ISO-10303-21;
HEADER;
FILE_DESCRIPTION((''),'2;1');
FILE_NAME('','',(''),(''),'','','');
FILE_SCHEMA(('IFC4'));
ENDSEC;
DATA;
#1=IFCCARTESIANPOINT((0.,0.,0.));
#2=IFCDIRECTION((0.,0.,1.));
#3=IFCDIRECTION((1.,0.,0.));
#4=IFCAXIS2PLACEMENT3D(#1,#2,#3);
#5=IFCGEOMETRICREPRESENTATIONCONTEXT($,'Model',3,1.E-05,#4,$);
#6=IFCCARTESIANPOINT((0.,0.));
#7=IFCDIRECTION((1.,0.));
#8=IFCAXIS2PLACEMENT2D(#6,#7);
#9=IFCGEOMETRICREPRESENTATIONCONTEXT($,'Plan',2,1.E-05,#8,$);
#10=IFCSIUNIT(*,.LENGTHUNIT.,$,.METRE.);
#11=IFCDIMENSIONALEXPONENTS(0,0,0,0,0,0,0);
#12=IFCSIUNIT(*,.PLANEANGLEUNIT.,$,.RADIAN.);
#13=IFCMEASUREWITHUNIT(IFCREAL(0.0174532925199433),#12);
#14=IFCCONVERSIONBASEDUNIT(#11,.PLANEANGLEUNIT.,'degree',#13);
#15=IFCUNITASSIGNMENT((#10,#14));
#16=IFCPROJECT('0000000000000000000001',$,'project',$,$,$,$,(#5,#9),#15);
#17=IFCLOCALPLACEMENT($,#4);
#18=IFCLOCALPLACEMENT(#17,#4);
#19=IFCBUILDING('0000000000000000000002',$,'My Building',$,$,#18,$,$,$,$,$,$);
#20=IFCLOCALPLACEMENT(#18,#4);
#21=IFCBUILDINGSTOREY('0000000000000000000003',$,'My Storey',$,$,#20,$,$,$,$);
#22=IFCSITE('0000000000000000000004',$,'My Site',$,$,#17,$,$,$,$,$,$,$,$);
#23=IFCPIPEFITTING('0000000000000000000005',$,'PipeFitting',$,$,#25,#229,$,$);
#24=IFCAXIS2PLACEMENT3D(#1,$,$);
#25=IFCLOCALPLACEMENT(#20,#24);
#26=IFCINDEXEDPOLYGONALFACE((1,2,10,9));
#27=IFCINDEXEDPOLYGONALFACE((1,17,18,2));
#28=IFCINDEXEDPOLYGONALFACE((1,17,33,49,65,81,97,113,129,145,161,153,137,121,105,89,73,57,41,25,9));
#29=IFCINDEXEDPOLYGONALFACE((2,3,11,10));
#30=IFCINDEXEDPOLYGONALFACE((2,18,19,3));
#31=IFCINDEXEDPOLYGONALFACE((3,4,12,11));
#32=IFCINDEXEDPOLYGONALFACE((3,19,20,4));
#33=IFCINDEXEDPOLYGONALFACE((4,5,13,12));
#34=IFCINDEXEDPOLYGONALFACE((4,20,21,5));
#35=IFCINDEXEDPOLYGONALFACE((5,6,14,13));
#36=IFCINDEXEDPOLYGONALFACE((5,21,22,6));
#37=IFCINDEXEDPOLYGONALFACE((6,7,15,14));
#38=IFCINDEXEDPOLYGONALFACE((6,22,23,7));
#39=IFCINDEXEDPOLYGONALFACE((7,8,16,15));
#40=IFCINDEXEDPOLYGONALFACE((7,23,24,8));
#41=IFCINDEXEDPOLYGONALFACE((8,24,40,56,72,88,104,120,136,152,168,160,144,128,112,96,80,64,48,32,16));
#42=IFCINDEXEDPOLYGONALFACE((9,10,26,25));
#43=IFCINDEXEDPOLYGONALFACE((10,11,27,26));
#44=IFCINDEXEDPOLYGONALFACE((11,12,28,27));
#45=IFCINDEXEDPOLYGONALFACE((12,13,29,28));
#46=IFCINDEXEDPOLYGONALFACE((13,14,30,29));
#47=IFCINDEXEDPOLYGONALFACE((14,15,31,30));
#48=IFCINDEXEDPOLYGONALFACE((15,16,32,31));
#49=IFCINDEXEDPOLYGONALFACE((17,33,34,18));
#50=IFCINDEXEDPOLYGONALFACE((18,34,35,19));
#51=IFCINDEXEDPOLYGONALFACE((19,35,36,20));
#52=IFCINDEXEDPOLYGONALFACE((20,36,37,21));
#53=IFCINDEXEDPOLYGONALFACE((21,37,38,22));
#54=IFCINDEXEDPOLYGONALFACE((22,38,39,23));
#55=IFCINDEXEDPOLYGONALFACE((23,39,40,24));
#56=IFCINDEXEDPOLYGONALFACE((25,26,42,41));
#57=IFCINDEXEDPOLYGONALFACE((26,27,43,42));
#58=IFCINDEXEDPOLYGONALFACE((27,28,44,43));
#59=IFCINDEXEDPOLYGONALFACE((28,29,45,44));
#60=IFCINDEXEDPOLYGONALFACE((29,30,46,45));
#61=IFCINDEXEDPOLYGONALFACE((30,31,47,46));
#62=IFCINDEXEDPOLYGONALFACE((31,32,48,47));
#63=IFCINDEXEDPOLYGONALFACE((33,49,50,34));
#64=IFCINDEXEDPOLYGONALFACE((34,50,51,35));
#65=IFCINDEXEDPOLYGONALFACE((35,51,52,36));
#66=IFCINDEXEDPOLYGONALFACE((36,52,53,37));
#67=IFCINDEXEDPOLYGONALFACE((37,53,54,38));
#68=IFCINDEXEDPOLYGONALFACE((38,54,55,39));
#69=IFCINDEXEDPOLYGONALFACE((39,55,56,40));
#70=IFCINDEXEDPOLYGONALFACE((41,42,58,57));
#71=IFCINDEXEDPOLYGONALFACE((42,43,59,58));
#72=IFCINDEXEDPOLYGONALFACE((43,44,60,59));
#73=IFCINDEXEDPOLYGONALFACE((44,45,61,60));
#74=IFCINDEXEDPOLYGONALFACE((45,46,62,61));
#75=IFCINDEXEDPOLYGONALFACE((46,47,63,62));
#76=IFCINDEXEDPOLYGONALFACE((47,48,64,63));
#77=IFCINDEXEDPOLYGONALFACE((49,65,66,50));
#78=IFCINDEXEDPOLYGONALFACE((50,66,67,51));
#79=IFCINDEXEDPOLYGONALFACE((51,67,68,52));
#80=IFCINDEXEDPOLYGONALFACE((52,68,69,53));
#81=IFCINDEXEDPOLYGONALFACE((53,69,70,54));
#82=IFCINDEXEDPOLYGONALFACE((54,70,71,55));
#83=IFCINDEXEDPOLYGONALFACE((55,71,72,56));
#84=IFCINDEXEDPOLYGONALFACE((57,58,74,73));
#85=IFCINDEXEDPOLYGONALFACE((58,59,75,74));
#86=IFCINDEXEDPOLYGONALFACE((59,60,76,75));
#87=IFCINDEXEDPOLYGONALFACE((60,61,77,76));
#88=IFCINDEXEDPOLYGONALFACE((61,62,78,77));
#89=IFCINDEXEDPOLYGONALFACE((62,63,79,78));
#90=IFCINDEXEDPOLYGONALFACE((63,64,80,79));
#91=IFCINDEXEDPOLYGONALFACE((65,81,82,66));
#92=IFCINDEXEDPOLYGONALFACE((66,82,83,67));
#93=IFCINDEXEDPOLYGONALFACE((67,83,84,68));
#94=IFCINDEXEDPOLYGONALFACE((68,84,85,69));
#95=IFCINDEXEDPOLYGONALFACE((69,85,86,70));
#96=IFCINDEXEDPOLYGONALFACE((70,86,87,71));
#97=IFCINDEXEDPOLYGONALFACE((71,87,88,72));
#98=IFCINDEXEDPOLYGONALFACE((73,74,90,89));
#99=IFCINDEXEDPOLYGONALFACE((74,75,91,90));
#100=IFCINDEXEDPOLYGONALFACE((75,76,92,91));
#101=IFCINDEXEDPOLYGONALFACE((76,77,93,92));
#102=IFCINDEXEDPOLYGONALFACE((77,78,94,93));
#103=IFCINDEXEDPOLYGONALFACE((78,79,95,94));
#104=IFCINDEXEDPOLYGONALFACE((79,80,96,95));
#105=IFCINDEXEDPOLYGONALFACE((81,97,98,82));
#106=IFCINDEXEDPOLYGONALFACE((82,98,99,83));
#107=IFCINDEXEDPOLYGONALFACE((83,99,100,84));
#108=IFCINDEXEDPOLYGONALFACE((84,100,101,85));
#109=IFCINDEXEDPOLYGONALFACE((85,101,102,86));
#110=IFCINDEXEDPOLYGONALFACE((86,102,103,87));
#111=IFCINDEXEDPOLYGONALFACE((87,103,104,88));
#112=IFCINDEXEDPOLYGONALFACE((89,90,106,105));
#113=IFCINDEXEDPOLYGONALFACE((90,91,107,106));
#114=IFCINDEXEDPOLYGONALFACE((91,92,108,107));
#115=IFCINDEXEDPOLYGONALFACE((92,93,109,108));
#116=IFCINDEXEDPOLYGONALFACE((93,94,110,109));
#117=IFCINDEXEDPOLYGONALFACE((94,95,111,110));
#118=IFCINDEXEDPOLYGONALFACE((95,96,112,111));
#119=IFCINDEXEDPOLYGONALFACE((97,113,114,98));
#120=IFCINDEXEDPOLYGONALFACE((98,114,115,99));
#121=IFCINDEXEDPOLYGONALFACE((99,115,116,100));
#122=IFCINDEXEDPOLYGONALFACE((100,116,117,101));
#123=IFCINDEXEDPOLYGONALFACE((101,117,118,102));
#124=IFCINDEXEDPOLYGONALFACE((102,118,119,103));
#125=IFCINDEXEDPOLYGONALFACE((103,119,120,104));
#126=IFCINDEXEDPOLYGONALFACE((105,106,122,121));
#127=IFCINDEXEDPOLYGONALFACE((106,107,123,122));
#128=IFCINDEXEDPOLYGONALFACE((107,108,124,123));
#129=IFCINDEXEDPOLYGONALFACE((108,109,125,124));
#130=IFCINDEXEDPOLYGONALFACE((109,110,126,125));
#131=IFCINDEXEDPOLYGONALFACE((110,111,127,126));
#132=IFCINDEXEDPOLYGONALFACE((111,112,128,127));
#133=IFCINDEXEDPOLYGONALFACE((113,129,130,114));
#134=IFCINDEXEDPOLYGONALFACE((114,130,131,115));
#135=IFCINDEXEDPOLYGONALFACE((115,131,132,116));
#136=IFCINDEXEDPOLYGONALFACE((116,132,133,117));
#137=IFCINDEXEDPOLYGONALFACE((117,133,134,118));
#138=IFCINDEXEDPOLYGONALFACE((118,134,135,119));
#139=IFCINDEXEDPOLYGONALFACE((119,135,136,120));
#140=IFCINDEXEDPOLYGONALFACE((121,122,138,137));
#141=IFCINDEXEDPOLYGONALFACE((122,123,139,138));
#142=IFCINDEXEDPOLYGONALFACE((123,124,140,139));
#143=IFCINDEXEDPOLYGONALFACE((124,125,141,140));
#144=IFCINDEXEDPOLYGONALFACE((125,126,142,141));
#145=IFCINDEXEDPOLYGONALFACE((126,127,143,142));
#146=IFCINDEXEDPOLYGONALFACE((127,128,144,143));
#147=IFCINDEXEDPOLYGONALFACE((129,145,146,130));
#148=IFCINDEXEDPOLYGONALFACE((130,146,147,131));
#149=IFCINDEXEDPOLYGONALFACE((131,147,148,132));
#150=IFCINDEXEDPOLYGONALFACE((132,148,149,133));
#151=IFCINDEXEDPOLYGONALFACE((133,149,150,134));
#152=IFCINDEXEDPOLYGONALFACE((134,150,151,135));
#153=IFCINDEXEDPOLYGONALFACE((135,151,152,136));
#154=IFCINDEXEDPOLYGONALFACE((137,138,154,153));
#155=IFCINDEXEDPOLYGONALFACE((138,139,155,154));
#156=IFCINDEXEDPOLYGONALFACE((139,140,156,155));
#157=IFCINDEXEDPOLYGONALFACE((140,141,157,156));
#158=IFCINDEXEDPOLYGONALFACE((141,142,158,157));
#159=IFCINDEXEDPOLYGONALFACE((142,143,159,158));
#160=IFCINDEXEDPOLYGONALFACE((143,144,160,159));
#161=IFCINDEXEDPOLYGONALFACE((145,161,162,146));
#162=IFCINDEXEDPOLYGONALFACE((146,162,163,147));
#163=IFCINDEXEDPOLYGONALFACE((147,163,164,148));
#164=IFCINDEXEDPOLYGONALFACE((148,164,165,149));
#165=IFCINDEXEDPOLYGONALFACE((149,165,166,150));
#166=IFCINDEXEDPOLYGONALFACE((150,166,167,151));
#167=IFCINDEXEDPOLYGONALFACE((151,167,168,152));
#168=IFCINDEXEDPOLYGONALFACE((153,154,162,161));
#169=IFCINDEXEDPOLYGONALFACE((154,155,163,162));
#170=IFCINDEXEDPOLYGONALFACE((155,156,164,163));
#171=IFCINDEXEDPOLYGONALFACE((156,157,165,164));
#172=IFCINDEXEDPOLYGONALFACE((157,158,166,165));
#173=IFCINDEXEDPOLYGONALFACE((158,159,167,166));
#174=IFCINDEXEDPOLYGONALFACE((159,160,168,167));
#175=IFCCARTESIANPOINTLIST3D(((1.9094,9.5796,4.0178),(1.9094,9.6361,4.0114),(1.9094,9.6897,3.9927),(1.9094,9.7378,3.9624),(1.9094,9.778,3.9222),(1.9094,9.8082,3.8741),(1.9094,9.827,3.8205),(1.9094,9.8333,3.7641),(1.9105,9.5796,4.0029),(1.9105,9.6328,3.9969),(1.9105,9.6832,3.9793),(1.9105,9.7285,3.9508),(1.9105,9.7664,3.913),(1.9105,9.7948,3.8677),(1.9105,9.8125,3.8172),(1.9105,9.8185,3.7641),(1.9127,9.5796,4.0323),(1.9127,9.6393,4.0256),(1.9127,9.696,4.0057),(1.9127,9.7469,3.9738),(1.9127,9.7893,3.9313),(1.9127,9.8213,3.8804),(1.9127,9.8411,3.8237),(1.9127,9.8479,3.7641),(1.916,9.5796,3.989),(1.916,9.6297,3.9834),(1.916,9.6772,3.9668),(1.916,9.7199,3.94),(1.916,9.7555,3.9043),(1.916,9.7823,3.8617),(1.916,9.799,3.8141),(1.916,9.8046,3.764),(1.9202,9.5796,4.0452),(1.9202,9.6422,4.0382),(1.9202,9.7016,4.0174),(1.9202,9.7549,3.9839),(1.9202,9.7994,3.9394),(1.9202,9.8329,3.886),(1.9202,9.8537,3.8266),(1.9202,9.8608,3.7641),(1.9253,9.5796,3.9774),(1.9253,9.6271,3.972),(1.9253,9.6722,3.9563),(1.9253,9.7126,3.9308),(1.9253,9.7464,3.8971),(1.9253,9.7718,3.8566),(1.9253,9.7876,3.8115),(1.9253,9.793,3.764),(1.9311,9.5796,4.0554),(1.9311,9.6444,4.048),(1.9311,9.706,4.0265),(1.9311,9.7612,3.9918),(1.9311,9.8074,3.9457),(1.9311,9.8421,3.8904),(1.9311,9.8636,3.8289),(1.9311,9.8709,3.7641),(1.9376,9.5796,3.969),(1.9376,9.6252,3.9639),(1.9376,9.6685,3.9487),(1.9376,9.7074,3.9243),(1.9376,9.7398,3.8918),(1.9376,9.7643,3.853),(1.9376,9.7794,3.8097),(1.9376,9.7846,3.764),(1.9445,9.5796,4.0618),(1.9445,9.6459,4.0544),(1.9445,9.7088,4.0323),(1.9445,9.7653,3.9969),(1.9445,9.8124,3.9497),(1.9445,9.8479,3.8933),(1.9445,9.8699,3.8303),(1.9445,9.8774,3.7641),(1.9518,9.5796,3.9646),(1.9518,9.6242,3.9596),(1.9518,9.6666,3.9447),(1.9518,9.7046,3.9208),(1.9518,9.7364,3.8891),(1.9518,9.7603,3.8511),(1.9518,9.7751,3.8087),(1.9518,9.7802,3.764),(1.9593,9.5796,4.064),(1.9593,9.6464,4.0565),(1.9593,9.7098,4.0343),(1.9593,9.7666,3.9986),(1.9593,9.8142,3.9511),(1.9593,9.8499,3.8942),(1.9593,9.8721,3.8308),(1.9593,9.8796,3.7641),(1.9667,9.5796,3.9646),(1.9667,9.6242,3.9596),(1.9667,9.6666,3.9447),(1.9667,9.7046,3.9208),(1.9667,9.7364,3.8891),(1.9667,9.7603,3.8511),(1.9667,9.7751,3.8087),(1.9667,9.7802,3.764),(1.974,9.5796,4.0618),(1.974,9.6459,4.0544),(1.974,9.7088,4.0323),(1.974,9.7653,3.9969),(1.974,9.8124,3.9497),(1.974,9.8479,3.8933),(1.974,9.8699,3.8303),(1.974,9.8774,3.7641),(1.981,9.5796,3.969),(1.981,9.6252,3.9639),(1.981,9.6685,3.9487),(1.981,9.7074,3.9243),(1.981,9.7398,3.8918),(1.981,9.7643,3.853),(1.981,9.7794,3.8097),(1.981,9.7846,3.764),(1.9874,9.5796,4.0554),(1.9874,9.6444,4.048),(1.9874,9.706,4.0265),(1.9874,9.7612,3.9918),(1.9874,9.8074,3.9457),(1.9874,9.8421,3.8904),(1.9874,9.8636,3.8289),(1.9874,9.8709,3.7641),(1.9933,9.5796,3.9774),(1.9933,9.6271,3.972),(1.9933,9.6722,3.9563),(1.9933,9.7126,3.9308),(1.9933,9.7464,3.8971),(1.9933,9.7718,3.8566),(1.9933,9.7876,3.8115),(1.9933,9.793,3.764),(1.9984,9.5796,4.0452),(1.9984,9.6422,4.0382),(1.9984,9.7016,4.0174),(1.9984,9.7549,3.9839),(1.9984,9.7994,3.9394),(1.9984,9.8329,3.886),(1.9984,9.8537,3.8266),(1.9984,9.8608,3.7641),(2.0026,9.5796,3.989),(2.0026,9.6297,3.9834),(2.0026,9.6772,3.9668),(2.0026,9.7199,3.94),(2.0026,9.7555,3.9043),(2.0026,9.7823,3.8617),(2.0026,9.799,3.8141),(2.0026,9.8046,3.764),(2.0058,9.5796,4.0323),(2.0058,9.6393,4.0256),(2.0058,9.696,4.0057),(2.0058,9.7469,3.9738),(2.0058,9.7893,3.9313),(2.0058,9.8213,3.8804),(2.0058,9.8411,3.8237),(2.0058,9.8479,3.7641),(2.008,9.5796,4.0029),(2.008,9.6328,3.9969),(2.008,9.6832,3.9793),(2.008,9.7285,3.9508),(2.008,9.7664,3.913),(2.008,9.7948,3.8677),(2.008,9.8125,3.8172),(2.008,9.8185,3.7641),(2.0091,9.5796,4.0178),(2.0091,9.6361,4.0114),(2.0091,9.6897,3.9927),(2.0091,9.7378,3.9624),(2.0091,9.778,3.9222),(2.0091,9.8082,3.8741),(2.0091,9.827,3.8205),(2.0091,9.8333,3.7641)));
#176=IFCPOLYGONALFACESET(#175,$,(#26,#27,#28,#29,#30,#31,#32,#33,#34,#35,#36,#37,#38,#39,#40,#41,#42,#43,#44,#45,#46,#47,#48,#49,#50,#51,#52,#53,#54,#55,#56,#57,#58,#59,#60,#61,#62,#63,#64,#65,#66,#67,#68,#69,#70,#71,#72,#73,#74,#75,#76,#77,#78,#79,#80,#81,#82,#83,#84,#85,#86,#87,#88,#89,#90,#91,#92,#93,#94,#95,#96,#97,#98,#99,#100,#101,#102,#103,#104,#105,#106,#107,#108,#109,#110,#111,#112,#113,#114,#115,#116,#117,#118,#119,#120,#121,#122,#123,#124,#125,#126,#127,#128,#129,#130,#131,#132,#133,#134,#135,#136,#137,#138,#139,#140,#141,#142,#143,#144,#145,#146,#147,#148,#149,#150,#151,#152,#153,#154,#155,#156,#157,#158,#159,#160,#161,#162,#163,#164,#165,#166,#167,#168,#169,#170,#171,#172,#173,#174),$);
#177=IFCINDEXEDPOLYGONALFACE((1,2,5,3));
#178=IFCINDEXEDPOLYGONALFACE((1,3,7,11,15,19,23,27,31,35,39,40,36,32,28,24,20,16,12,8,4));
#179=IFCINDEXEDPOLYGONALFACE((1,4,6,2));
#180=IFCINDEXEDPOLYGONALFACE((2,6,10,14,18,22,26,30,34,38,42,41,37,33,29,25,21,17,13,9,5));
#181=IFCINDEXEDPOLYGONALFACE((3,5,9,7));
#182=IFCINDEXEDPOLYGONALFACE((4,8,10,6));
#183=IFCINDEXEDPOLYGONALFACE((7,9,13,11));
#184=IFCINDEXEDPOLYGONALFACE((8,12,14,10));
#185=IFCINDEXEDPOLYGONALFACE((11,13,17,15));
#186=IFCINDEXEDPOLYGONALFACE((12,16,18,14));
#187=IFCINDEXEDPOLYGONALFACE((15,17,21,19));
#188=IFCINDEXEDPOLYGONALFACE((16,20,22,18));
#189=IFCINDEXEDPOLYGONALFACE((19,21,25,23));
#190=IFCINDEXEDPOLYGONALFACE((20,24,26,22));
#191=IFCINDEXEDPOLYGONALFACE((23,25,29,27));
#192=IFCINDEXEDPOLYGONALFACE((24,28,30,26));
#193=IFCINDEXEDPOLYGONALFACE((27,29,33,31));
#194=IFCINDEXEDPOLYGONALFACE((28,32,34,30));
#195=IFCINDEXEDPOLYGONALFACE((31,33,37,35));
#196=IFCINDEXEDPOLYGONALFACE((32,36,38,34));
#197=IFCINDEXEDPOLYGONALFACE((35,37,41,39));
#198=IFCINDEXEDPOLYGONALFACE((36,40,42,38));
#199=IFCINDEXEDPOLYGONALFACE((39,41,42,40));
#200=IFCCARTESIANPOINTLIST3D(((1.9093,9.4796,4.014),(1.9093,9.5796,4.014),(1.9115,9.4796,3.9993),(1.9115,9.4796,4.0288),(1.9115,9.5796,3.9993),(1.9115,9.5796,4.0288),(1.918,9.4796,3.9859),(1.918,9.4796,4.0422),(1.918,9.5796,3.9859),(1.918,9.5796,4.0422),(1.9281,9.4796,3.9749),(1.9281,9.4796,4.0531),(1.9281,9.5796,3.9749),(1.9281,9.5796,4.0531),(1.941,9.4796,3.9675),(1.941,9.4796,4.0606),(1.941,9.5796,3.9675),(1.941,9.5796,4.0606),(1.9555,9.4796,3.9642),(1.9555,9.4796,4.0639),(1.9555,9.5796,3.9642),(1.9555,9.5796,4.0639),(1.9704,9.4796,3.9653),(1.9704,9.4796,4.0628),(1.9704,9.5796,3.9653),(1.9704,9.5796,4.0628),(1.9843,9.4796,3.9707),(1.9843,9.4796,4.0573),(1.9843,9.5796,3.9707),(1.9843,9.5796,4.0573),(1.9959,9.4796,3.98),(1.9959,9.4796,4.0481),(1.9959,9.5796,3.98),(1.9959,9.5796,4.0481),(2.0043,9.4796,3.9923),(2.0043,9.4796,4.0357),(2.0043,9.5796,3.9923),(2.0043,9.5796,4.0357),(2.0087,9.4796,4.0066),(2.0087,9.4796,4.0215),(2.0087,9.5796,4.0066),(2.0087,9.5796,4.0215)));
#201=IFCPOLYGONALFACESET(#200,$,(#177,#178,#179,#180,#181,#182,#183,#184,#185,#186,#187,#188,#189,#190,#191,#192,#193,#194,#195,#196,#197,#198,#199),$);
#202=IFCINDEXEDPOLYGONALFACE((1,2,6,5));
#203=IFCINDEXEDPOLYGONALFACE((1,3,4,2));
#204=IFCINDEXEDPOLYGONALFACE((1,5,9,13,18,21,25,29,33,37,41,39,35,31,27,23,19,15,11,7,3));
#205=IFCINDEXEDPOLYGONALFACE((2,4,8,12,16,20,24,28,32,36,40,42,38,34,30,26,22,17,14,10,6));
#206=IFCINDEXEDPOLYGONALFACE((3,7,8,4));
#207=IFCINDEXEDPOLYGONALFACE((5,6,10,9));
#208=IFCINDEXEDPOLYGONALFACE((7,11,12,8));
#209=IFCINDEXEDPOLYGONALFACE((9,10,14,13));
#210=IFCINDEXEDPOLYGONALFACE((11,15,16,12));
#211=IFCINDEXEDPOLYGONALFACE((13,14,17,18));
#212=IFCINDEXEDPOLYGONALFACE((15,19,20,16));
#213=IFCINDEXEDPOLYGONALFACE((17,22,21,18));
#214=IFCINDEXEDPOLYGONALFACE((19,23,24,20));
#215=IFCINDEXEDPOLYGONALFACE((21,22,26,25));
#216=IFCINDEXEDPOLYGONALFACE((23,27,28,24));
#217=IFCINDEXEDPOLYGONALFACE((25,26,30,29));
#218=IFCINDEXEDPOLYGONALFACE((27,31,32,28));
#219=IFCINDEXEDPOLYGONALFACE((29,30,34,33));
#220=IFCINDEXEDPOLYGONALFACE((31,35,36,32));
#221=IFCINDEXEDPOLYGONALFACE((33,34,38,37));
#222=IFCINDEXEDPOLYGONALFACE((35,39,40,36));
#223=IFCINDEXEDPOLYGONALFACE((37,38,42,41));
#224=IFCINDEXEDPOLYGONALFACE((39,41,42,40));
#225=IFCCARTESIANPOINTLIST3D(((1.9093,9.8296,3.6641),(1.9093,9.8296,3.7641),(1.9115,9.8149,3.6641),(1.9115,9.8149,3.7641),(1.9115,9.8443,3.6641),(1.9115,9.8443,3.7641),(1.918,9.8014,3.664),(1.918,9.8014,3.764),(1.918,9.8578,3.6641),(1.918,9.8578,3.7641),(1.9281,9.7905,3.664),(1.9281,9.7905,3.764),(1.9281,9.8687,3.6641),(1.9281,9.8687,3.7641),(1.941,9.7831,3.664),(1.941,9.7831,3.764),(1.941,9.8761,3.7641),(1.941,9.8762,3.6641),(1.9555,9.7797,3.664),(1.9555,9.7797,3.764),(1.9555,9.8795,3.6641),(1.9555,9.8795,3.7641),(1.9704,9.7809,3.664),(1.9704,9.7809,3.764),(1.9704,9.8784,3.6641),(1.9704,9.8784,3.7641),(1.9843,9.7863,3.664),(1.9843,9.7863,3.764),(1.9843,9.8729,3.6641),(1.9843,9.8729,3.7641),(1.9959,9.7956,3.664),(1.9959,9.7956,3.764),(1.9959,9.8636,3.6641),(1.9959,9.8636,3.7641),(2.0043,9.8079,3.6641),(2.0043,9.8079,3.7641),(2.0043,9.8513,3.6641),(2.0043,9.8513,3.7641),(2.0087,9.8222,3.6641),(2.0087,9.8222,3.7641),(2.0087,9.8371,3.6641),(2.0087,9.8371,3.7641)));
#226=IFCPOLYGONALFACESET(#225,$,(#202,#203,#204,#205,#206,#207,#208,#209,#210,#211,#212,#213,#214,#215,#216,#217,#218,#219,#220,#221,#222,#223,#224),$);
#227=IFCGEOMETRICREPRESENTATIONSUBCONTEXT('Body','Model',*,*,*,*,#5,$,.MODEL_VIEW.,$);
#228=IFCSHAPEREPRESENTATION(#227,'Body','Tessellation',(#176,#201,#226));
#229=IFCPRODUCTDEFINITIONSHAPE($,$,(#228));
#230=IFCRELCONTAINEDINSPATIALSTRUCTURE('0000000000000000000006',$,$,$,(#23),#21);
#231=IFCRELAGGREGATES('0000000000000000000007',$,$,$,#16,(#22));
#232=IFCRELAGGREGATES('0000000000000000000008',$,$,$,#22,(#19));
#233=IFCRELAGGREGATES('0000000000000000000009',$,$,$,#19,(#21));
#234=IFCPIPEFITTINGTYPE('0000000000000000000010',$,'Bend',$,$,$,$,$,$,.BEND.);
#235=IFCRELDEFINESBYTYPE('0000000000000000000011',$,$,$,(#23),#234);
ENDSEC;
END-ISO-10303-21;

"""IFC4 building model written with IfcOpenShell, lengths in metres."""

from ifc_helpers import new_model, entity, si_unit, converted_unit, frame, origin_with_axes, origin_2d_with_axis, place, context, subcontext, project, spatial, circle, extrude, source, transform, mapped, type_object, type_shapes, element, save


model = new_model("IFC4")

# Units and contexts
model_context = context("Model", 3, precision=1e-05, world=origin_with_axes())
plan_context = context("Plan", 2, precision=1e-05, world=origin_2d_with_axis())
body_context = subcontext(model_context, "Body", "Model", "MODEL_VIEW")
ifc_project = project(units=[si_unit("LENGTHUNIT", "METRE"), converted_unit("PLANEANGLEUNIT", "degree", entity("IfcReal", 0.0174532925199433), si_unit("PLANEANGLEUNIT", "RADIAN"), dimensions=[0, 0, 0, 0, 0, 0, 0])], contexts=[model_context, plan_context])

# Site, building, storey
site_placement = place(None, origin_with_axes())
site = spatial("IfcSite", under=ifc_project, at=site_placement, Name="My Site")
building_placement = place(site_placement, origin_with_axes())
building = spatial("IfcBuilding", under=site, at=building_placement, Name="My Building")
storey_placement = place(building_placement, origin_with_axes())
storey = spatial("IfcBuildingStorey", under=building, at=storey_placement, Name="My Storey")

# Pipe fitting
pipe_fitting_type_1 = type_object("IfcPipeFittingType", Name="Bend", PredefinedType="BEND")
shared_shape_1 = source(origin_with_axes(), body_context, "Body", "SolidModel", [
    entity("IfcSweptDiskSolid", entity("IfcIndexedPolyCurve", entity("IfcCartesianPointList3D", [[0.0, 0.0, 0.1], [0.0, -0.0732, 0.2768], [0.0, -0.25, 0.35]]), [entity("IfcArcIndex", [1, 2, 3])]), 0.05),
    extrude(circle(Radius=0.05), origin_with_axes(), (0.0, 0.0, 1.0), 0.1),
    extrude(circle(Radius=0.05), frame((0.0, -0.25, 0.35), z_axis=(0.0, -1.0, 0.000038), x_axis=(1.0, 0.0, 0.0)), (0.0, 0.0, 1.0), 0.1),
])
type_shapes(pipe_fitting_type_1, [shared_shape_1])
for number, where, z_axis, x_axis, name in (
    (1, (1.9593, 9.4796, 4.014), (0.0, 1.0, 0.0), (-1.0, 0.0, 0.0), "PipeFitting"),
):
    element("IfcPipeFitting", number, at=place(storey_placement, frame(where, z_axis=z_axis, x_axis=x_axis)), inside=storey, type_object=pipe_fitting_type_1, Name=name, context=body_context, shape_type="MappedRepresentation", body=[
        mapped(shared_shape_1, transform((0.0, 0.0, 0.0), x_axis=(1.0, 0.0, 0.0), y_axis=(0.0, 1.0, 0.0), z_axis=(0.0, 0.0, 1.0), scale=1.0)),
    ])

save(model, "model.ifc")
